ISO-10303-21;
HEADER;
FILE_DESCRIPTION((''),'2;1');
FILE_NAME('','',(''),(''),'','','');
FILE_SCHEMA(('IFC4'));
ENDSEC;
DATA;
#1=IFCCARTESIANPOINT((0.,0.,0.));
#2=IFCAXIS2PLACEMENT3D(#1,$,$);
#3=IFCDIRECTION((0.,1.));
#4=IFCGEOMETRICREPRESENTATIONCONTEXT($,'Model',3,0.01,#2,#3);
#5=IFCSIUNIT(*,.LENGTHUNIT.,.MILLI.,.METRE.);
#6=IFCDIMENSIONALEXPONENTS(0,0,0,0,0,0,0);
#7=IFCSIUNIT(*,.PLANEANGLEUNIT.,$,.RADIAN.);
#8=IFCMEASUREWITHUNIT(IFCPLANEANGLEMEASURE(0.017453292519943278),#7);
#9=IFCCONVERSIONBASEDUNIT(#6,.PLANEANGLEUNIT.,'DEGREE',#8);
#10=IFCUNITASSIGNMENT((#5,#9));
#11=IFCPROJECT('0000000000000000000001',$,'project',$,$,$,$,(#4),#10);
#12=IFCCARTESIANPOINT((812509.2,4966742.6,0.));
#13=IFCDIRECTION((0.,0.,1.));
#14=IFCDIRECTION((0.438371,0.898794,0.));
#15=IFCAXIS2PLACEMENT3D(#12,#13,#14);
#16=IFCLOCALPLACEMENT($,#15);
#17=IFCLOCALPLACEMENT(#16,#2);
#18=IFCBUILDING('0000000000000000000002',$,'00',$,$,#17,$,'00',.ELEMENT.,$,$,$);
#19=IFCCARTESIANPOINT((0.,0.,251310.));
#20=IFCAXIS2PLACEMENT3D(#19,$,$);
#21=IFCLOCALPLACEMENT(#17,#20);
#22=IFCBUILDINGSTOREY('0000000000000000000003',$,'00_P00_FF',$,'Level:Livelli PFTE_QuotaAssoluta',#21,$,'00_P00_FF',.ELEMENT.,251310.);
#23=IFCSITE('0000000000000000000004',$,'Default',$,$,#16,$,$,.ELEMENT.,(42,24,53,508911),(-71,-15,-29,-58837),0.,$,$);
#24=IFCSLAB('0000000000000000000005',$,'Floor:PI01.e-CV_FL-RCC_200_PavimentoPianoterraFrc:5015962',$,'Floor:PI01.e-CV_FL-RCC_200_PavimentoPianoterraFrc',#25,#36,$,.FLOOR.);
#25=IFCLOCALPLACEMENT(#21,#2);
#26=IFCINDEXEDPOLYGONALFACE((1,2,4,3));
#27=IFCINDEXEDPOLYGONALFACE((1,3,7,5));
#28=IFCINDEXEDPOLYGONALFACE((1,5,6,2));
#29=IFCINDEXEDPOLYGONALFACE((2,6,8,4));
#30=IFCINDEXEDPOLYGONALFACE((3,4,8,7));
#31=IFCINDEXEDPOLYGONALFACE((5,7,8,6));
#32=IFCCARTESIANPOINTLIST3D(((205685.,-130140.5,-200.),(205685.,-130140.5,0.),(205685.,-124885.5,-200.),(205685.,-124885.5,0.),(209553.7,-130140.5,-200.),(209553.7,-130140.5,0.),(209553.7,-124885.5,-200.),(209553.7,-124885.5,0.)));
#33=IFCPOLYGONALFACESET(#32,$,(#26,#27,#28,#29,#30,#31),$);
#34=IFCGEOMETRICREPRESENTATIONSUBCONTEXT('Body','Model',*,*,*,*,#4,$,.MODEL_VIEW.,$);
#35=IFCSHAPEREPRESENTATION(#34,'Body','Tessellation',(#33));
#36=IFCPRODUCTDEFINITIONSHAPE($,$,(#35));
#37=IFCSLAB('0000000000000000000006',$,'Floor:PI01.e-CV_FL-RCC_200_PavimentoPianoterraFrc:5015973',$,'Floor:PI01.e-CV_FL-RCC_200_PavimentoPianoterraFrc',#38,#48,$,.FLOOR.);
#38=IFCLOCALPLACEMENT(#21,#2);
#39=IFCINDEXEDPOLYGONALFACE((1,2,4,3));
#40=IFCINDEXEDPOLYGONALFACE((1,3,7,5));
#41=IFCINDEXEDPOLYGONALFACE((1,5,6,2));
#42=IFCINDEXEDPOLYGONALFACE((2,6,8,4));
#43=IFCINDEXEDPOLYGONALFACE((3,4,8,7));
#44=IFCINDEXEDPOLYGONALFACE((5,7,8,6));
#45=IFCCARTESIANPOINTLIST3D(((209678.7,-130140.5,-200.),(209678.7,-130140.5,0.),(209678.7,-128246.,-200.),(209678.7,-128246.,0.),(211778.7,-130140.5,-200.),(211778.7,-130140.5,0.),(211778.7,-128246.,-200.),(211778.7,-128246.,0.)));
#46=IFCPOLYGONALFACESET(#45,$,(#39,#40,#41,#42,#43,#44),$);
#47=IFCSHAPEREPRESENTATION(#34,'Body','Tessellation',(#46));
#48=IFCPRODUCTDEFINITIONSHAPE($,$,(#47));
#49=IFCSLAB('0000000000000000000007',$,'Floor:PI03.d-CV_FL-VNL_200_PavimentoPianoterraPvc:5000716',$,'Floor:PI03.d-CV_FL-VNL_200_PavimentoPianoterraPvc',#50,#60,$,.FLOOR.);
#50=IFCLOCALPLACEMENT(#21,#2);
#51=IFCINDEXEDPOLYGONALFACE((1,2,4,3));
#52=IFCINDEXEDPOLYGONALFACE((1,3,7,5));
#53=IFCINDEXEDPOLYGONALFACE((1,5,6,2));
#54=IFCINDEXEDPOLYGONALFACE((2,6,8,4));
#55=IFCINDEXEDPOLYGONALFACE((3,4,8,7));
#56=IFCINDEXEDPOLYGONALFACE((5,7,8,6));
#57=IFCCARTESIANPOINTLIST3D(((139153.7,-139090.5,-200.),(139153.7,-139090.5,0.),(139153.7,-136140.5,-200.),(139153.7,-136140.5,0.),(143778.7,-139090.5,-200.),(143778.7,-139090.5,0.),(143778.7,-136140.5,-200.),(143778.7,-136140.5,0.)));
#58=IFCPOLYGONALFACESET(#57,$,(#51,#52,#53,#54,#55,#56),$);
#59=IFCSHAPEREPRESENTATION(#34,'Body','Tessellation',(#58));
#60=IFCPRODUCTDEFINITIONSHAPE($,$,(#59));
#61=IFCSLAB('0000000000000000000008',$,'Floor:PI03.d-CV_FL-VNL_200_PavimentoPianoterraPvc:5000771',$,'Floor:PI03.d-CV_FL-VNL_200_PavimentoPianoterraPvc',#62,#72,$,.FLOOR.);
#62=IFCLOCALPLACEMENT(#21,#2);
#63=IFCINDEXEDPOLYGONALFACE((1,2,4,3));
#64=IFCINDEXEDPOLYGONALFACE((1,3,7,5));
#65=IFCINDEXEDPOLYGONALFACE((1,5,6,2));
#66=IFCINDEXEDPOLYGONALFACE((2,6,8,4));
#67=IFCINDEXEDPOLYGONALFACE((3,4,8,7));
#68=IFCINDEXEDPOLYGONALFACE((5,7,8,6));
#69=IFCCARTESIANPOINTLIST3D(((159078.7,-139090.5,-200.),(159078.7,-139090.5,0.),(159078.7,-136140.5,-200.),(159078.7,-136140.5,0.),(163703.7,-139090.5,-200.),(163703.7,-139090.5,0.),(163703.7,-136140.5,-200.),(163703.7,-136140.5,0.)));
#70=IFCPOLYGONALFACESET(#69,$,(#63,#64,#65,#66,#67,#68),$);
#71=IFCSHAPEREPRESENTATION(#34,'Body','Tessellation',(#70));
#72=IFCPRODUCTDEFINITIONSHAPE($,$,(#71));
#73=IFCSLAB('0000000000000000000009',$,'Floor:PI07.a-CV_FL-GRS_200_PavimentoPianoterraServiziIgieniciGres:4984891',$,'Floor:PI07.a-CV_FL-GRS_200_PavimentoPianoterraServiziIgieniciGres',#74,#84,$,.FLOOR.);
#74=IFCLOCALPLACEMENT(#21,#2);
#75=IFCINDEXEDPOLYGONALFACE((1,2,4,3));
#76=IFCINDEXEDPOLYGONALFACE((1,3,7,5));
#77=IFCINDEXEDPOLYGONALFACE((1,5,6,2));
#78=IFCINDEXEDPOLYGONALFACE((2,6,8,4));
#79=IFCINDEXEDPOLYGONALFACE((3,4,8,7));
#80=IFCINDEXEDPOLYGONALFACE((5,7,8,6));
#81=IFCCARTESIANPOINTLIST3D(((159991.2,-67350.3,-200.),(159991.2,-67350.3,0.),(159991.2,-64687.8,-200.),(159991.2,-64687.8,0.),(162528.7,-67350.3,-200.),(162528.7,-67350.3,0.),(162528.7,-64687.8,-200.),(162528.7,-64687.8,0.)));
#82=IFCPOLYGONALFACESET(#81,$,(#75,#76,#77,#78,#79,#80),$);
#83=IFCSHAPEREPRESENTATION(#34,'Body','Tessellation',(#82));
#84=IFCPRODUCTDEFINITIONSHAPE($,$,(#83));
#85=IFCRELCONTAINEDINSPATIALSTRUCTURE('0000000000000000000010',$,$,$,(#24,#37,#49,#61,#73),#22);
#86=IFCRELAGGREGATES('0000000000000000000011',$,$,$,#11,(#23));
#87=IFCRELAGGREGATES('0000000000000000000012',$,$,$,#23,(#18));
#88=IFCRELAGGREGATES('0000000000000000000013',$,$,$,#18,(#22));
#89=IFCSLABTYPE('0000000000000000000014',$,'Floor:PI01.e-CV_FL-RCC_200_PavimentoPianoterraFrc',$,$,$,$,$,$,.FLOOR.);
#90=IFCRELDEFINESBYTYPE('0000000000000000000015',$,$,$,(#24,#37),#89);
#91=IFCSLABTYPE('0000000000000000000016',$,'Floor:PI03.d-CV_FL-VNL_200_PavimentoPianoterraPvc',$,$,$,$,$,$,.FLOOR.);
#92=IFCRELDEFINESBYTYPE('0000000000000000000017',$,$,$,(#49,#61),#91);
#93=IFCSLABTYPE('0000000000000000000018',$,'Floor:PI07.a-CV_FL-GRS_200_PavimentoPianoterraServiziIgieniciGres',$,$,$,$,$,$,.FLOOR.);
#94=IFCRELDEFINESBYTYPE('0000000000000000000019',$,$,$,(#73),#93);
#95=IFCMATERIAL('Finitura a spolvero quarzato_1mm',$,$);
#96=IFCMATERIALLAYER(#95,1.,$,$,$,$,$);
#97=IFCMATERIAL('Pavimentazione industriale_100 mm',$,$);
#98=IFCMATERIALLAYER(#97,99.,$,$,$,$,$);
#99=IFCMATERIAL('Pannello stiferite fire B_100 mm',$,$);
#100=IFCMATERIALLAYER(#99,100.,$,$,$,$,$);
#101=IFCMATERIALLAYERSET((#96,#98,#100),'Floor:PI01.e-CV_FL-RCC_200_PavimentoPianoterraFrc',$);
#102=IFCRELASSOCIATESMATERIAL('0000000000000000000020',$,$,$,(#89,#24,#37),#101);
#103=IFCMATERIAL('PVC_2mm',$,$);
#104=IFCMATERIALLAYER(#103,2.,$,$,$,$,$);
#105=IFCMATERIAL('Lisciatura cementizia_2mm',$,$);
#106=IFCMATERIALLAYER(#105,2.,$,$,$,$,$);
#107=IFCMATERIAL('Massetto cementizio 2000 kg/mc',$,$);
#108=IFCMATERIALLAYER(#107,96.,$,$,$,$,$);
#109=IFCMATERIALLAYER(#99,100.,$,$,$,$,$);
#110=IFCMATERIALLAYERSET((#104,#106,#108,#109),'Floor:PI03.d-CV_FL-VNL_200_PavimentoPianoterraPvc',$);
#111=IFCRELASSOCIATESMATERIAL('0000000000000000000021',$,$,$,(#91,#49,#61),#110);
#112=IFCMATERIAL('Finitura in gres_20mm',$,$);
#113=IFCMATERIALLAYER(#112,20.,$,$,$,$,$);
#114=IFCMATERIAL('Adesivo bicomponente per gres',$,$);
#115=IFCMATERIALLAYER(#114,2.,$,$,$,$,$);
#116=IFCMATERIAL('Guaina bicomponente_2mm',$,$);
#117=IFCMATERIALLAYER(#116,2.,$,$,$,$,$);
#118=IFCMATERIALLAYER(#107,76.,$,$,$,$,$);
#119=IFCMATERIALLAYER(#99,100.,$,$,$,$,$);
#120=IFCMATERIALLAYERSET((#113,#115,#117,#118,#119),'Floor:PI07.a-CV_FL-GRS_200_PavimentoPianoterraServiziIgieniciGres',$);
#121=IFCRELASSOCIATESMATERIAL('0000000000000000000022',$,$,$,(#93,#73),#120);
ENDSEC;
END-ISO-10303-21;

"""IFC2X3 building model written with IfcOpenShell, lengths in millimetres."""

from ifc_helpers import new_model, entity, si_unit, converted_unit, direction, frame, frame_2d, origin, origin_2d_with_axis, place, context, subcontext, project, spatial, rectangle, extrude, material, layer, layer_set, layer_usage, type_object, element, save


model = new_model("IFC2X3")

# Units and contexts
model_context = context("Model", 3, precision=0.01, world=origin(), true_north=direction((0.0, 1.0)))
body_context = subcontext(model_context, "Body", "Model", "MODEL_VIEW")
ifc_project = project(units=[si_unit("LENGTHUNIT", "METRE", prefix="MILLI"), converted_unit("PLANEANGLEUNIT", "DEGREE", entity("IfcPlaneAngleMeasure", 0.017453292519943278), si_unit("PLANEANGLEUNIT", "RADIAN"), dimensions=[0, 0, 0, 0, 0, 0, 0])], contexts=[model_context])

# Site, building, storey
site_placement = place(None, frame((812509.2, 4966742.6, 0.0), z_axis=(0.0, 0.0, 1.0), x_axis=(0.438371, 0.898794, 0.0)))
site = spatial("IfcSite", under=ifc_project, at=site_placement, Name="Default", CompositionType="ELEMENT", RefLatitude=(42, 24, 53, 508911), RefLongitude=(-71, -15, -29, -58837), RefElevation=0.0)
building_placement = place(site_placement, origin())
building = spatial("IfcBuilding", under=site, at=building_placement, Name="00", LongName="00", CompositionType="ELEMENT")
storey_placement = place(building_placement, frame((0.0, 0.0, 251310.0)))
storey = spatial("IfcBuildingStorey", under=building, at=storey_placement, Name="00_P00_FF", ObjectType="Level:Livelli PFTE_QuotaAssoluta", LongName="00_P00_FF", CompositionType="ELEMENT", Elevation=251310.0)

# Shared definitions
ifc_material_1 = material(Name="Massetto cementizio 2000 kg/mc")
ifc_material_2 = material(Name="Pannello stiferite fire B_100 mm")

# Slabs
ifc_material_3 = material(Name="Finitura a spolvero quarzato_1mm")
ifc_layer_1 = layer(ifc_material_3, 1.0)
ifc_material_4 = material(Name="Pavimentazione industriale_100 mm")
ifc_layer_2 = layer(ifc_material_4, 99.0)
ifc_layer_3 = layer(ifc_material_2, 100.0)
ifc_layer_set_1 = layer_set([ifc_layer_1, ifc_layer_2, ifc_layer_3], Name="Floor:PI01.e-CV_FL-RCC_200_PavimentoPianoterraFrc")
slab_type_1 = type_object("IfcSlabType", Name="Floor:PI01.e-CV_FL-RCC_200_PavimentoPianoterraFrc", PredefinedType="FLOOR", material=ifc_layer_set_1)
ifc_layer_usage_1 = layer_usage(ifc_layer_set_1, "AXIS3", "POSITIVE", 0.0)
slab_1_placement = place(storey_placement, origin())
element("IfcSlab", 1, at=slab_1_placement, inside=storey, type_object=slab_type_1, material=ifc_layer_usage_1, Name="Floor:PI01.e-CV_FL-RCC_200_PavimentoPianoterraFrc:5015962", ObjectType="Floor:PI01.e-CV_FL-RCC_200_PavimentoPianoterraFrc", PredefinedType="FLOOR", context=body_context, shape_type="SweptSolid", body=[
    extrude(rectangle(XDim=5255.0, YDim=3868.8, at=frame_2d((0.0, 0.0), x_axis=(1.0, 0.0))), frame((207619.3, -127513.0, 0.0), z_axis=(0.0, 0.0, -1.0), x_axis=(0.0, 1.0, 0.0)), (0.0, 0.0, 1.0), 200.0),
])
ifc_layer_usage_2 = layer_usage(ifc_layer_set_1, "AXIS3", "POSITIVE", 0.0)
slab_2_placement = place(storey_placement, origin())
element("IfcSlab", 2, at=slab_2_placement, inside=storey, type_object=slab_type_1, material=ifc_layer_usage_2, Name="Floor:PI01.e-CV_FL-RCC_200_PavimentoPianoterraFrc:5015973", ObjectType="Floor:PI01.e-CV_FL-RCC_200_PavimentoPianoterraFrc", PredefinedType="FLOOR", context=body_context, shape_type="SweptSolid", body=[
    extrude(rectangle(XDim=1894.5, YDim=2100.0, at=origin_2d_with_axis()), frame((210728.7, -129193.2, 0.0), z_axis=(0.0, 0.0, -1.0), x_axis=(0.0, 1.0, 0.0)), (0.0, 0.0, 1.0), 200.0),
])

# Shared definitions
ifc_material_5 = material(Name="PVC_2mm")
ifc_layer_4 = layer(ifc_material_5, 2.0)
ifc_material_6 = material(Name="Lisciatura cementizia_2mm")
ifc_layer_5 = layer(ifc_material_6, 2.0)
ifc_layer_6 = layer(ifc_material_1, 96.0)
ifc_layer_7 = layer(ifc_material_2, 100.0)
ifc_layer_set_2 = layer_set([ifc_layer_4, ifc_layer_5, ifc_layer_6, ifc_layer_7], Name="Floor:PI03.d-CV_FL-VNL_200_PavimentoPianoterraPvc")
slab_type_2 = type_object("IfcSlabType", Name="Floor:PI03.d-CV_FL-VNL_200_PavimentoPianoterraPvc", PredefinedType="FLOOR", material=ifc_layer_set_2)

# Slabs
ifc_layer_usage_3 = layer_usage(ifc_layer_set_2, "AXIS3", "POSITIVE", 0.0)
slab_3_placement = place(storey_placement, origin())
element("IfcSlab", 3, at=slab_3_placement, inside=storey, type_object=slab_type_2, material=ifc_layer_usage_3, Name="Floor:PI03.d-CV_FL-VNL_200_PavimentoPianoterraPvc:5000716", ObjectType="Floor:PI03.d-CV_FL-VNL_200_PavimentoPianoterraPvc", PredefinedType="FLOOR", context=body_context, shape_type="SweptSolid", body=[
    extrude(rectangle(XDim=2950.0, YDim=4625.0, at=frame_2d((0.0, 0.0), x_axis=(1.0, 0.0))), frame((141466.2, -137615.5, 0.0), z_axis=(0.0, 0.0, -1.0), x_axis=(0.0, 1.0, 0.0)), (0.0, 0.0, 1.0), 200.0),
])
ifc_layer_usage_4 = layer_usage(ifc_layer_set_2, "AXIS3", "POSITIVE", 0.0)
slab_4_placement = place(storey_placement, origin())
element("IfcSlab", 4, at=slab_4_placement, inside=storey, type_object=slab_type_2, material=ifc_layer_usage_4, Name="Floor:PI03.d-CV_FL-VNL_200_PavimentoPianoterraPvc:5000771", ObjectType="Floor:PI03.d-CV_FL-VNL_200_PavimentoPianoterraPvc", PredefinedType="FLOOR", context=body_context, shape_type="SweptSolid", body=[
    extrude(rectangle(XDim=2950.0, YDim=4625.0, at=frame_2d((0.0, 0.0), x_axis=(1.0, 0.0))), frame((161391.2, -137615.5, 0.0), z_axis=(0.0, 0.0, -1.0), x_axis=(0.0, 1.0, 0.0)), (0.0, 0.0, 1.0), 200.0),
])
ifc_material_7 = material(Name="Finitura in gres_20mm")
ifc_layer_8 = layer(ifc_material_7, 20.0)
ifc_material_8 = material(Name="Adesivo bicomponente per gres")
ifc_layer_9 = layer(ifc_material_8, 2.0)
ifc_material_9 = material(Name="Guaina bicomponente_2mm")
ifc_layer_10 = layer(ifc_material_9, 2.0)
ifc_layer_11 = layer(ifc_material_1, 76.0)
ifc_layer_12 = layer(ifc_material_2, 100.0)
ifc_layer_set_3 = layer_set([ifc_layer_8, ifc_layer_9, ifc_layer_10, ifc_layer_11, ifc_layer_12], Name="Floor:PI07.a-CV_FL-GRS_200_PavimentoPianoterraServiziIgieniciGres")
ifc_layer_usage_5 = layer_usage(ifc_layer_set_3, "AXIS3", "POSITIVE", 0.0)
slab_type_3 = type_object("IfcSlabType", Name="Floor:PI07.a-CV_FL-GRS_200_PavimentoPianoterraServiziIgieniciGres", PredefinedType="FLOOR", material=ifc_layer_set_3)
slab_5_placement = place(storey_placement, origin())
element("IfcSlab", 5, at=slab_5_placement, inside=storey, type_object=slab_type_3, material=ifc_layer_usage_5, Name="Floor:PI07.a-CV_FL-GRS_200_PavimentoPianoterraServiziIgieniciGres:4984891", ObjectType="Floor:PI07.a-CV_FL-GRS_200_PavimentoPianoterraServiziIgieniciGres", PredefinedType="FLOOR", context=body_context, shape_type="SweptSolid", body=[
    extrude(rectangle(XDim=2662.5, YDim=2537.5, at=frame_2d((0.0, 0.0), x_axis=(1.0, 0.0))), frame((161259.9, -66019.1, 0.0), z_axis=(0.0, 0.0, -1.0), x_axis=(0.0, 1.0, 0.0)), (0.0, 0.0, 1.0), 200.0),
])

save(model, "model.ifc")
